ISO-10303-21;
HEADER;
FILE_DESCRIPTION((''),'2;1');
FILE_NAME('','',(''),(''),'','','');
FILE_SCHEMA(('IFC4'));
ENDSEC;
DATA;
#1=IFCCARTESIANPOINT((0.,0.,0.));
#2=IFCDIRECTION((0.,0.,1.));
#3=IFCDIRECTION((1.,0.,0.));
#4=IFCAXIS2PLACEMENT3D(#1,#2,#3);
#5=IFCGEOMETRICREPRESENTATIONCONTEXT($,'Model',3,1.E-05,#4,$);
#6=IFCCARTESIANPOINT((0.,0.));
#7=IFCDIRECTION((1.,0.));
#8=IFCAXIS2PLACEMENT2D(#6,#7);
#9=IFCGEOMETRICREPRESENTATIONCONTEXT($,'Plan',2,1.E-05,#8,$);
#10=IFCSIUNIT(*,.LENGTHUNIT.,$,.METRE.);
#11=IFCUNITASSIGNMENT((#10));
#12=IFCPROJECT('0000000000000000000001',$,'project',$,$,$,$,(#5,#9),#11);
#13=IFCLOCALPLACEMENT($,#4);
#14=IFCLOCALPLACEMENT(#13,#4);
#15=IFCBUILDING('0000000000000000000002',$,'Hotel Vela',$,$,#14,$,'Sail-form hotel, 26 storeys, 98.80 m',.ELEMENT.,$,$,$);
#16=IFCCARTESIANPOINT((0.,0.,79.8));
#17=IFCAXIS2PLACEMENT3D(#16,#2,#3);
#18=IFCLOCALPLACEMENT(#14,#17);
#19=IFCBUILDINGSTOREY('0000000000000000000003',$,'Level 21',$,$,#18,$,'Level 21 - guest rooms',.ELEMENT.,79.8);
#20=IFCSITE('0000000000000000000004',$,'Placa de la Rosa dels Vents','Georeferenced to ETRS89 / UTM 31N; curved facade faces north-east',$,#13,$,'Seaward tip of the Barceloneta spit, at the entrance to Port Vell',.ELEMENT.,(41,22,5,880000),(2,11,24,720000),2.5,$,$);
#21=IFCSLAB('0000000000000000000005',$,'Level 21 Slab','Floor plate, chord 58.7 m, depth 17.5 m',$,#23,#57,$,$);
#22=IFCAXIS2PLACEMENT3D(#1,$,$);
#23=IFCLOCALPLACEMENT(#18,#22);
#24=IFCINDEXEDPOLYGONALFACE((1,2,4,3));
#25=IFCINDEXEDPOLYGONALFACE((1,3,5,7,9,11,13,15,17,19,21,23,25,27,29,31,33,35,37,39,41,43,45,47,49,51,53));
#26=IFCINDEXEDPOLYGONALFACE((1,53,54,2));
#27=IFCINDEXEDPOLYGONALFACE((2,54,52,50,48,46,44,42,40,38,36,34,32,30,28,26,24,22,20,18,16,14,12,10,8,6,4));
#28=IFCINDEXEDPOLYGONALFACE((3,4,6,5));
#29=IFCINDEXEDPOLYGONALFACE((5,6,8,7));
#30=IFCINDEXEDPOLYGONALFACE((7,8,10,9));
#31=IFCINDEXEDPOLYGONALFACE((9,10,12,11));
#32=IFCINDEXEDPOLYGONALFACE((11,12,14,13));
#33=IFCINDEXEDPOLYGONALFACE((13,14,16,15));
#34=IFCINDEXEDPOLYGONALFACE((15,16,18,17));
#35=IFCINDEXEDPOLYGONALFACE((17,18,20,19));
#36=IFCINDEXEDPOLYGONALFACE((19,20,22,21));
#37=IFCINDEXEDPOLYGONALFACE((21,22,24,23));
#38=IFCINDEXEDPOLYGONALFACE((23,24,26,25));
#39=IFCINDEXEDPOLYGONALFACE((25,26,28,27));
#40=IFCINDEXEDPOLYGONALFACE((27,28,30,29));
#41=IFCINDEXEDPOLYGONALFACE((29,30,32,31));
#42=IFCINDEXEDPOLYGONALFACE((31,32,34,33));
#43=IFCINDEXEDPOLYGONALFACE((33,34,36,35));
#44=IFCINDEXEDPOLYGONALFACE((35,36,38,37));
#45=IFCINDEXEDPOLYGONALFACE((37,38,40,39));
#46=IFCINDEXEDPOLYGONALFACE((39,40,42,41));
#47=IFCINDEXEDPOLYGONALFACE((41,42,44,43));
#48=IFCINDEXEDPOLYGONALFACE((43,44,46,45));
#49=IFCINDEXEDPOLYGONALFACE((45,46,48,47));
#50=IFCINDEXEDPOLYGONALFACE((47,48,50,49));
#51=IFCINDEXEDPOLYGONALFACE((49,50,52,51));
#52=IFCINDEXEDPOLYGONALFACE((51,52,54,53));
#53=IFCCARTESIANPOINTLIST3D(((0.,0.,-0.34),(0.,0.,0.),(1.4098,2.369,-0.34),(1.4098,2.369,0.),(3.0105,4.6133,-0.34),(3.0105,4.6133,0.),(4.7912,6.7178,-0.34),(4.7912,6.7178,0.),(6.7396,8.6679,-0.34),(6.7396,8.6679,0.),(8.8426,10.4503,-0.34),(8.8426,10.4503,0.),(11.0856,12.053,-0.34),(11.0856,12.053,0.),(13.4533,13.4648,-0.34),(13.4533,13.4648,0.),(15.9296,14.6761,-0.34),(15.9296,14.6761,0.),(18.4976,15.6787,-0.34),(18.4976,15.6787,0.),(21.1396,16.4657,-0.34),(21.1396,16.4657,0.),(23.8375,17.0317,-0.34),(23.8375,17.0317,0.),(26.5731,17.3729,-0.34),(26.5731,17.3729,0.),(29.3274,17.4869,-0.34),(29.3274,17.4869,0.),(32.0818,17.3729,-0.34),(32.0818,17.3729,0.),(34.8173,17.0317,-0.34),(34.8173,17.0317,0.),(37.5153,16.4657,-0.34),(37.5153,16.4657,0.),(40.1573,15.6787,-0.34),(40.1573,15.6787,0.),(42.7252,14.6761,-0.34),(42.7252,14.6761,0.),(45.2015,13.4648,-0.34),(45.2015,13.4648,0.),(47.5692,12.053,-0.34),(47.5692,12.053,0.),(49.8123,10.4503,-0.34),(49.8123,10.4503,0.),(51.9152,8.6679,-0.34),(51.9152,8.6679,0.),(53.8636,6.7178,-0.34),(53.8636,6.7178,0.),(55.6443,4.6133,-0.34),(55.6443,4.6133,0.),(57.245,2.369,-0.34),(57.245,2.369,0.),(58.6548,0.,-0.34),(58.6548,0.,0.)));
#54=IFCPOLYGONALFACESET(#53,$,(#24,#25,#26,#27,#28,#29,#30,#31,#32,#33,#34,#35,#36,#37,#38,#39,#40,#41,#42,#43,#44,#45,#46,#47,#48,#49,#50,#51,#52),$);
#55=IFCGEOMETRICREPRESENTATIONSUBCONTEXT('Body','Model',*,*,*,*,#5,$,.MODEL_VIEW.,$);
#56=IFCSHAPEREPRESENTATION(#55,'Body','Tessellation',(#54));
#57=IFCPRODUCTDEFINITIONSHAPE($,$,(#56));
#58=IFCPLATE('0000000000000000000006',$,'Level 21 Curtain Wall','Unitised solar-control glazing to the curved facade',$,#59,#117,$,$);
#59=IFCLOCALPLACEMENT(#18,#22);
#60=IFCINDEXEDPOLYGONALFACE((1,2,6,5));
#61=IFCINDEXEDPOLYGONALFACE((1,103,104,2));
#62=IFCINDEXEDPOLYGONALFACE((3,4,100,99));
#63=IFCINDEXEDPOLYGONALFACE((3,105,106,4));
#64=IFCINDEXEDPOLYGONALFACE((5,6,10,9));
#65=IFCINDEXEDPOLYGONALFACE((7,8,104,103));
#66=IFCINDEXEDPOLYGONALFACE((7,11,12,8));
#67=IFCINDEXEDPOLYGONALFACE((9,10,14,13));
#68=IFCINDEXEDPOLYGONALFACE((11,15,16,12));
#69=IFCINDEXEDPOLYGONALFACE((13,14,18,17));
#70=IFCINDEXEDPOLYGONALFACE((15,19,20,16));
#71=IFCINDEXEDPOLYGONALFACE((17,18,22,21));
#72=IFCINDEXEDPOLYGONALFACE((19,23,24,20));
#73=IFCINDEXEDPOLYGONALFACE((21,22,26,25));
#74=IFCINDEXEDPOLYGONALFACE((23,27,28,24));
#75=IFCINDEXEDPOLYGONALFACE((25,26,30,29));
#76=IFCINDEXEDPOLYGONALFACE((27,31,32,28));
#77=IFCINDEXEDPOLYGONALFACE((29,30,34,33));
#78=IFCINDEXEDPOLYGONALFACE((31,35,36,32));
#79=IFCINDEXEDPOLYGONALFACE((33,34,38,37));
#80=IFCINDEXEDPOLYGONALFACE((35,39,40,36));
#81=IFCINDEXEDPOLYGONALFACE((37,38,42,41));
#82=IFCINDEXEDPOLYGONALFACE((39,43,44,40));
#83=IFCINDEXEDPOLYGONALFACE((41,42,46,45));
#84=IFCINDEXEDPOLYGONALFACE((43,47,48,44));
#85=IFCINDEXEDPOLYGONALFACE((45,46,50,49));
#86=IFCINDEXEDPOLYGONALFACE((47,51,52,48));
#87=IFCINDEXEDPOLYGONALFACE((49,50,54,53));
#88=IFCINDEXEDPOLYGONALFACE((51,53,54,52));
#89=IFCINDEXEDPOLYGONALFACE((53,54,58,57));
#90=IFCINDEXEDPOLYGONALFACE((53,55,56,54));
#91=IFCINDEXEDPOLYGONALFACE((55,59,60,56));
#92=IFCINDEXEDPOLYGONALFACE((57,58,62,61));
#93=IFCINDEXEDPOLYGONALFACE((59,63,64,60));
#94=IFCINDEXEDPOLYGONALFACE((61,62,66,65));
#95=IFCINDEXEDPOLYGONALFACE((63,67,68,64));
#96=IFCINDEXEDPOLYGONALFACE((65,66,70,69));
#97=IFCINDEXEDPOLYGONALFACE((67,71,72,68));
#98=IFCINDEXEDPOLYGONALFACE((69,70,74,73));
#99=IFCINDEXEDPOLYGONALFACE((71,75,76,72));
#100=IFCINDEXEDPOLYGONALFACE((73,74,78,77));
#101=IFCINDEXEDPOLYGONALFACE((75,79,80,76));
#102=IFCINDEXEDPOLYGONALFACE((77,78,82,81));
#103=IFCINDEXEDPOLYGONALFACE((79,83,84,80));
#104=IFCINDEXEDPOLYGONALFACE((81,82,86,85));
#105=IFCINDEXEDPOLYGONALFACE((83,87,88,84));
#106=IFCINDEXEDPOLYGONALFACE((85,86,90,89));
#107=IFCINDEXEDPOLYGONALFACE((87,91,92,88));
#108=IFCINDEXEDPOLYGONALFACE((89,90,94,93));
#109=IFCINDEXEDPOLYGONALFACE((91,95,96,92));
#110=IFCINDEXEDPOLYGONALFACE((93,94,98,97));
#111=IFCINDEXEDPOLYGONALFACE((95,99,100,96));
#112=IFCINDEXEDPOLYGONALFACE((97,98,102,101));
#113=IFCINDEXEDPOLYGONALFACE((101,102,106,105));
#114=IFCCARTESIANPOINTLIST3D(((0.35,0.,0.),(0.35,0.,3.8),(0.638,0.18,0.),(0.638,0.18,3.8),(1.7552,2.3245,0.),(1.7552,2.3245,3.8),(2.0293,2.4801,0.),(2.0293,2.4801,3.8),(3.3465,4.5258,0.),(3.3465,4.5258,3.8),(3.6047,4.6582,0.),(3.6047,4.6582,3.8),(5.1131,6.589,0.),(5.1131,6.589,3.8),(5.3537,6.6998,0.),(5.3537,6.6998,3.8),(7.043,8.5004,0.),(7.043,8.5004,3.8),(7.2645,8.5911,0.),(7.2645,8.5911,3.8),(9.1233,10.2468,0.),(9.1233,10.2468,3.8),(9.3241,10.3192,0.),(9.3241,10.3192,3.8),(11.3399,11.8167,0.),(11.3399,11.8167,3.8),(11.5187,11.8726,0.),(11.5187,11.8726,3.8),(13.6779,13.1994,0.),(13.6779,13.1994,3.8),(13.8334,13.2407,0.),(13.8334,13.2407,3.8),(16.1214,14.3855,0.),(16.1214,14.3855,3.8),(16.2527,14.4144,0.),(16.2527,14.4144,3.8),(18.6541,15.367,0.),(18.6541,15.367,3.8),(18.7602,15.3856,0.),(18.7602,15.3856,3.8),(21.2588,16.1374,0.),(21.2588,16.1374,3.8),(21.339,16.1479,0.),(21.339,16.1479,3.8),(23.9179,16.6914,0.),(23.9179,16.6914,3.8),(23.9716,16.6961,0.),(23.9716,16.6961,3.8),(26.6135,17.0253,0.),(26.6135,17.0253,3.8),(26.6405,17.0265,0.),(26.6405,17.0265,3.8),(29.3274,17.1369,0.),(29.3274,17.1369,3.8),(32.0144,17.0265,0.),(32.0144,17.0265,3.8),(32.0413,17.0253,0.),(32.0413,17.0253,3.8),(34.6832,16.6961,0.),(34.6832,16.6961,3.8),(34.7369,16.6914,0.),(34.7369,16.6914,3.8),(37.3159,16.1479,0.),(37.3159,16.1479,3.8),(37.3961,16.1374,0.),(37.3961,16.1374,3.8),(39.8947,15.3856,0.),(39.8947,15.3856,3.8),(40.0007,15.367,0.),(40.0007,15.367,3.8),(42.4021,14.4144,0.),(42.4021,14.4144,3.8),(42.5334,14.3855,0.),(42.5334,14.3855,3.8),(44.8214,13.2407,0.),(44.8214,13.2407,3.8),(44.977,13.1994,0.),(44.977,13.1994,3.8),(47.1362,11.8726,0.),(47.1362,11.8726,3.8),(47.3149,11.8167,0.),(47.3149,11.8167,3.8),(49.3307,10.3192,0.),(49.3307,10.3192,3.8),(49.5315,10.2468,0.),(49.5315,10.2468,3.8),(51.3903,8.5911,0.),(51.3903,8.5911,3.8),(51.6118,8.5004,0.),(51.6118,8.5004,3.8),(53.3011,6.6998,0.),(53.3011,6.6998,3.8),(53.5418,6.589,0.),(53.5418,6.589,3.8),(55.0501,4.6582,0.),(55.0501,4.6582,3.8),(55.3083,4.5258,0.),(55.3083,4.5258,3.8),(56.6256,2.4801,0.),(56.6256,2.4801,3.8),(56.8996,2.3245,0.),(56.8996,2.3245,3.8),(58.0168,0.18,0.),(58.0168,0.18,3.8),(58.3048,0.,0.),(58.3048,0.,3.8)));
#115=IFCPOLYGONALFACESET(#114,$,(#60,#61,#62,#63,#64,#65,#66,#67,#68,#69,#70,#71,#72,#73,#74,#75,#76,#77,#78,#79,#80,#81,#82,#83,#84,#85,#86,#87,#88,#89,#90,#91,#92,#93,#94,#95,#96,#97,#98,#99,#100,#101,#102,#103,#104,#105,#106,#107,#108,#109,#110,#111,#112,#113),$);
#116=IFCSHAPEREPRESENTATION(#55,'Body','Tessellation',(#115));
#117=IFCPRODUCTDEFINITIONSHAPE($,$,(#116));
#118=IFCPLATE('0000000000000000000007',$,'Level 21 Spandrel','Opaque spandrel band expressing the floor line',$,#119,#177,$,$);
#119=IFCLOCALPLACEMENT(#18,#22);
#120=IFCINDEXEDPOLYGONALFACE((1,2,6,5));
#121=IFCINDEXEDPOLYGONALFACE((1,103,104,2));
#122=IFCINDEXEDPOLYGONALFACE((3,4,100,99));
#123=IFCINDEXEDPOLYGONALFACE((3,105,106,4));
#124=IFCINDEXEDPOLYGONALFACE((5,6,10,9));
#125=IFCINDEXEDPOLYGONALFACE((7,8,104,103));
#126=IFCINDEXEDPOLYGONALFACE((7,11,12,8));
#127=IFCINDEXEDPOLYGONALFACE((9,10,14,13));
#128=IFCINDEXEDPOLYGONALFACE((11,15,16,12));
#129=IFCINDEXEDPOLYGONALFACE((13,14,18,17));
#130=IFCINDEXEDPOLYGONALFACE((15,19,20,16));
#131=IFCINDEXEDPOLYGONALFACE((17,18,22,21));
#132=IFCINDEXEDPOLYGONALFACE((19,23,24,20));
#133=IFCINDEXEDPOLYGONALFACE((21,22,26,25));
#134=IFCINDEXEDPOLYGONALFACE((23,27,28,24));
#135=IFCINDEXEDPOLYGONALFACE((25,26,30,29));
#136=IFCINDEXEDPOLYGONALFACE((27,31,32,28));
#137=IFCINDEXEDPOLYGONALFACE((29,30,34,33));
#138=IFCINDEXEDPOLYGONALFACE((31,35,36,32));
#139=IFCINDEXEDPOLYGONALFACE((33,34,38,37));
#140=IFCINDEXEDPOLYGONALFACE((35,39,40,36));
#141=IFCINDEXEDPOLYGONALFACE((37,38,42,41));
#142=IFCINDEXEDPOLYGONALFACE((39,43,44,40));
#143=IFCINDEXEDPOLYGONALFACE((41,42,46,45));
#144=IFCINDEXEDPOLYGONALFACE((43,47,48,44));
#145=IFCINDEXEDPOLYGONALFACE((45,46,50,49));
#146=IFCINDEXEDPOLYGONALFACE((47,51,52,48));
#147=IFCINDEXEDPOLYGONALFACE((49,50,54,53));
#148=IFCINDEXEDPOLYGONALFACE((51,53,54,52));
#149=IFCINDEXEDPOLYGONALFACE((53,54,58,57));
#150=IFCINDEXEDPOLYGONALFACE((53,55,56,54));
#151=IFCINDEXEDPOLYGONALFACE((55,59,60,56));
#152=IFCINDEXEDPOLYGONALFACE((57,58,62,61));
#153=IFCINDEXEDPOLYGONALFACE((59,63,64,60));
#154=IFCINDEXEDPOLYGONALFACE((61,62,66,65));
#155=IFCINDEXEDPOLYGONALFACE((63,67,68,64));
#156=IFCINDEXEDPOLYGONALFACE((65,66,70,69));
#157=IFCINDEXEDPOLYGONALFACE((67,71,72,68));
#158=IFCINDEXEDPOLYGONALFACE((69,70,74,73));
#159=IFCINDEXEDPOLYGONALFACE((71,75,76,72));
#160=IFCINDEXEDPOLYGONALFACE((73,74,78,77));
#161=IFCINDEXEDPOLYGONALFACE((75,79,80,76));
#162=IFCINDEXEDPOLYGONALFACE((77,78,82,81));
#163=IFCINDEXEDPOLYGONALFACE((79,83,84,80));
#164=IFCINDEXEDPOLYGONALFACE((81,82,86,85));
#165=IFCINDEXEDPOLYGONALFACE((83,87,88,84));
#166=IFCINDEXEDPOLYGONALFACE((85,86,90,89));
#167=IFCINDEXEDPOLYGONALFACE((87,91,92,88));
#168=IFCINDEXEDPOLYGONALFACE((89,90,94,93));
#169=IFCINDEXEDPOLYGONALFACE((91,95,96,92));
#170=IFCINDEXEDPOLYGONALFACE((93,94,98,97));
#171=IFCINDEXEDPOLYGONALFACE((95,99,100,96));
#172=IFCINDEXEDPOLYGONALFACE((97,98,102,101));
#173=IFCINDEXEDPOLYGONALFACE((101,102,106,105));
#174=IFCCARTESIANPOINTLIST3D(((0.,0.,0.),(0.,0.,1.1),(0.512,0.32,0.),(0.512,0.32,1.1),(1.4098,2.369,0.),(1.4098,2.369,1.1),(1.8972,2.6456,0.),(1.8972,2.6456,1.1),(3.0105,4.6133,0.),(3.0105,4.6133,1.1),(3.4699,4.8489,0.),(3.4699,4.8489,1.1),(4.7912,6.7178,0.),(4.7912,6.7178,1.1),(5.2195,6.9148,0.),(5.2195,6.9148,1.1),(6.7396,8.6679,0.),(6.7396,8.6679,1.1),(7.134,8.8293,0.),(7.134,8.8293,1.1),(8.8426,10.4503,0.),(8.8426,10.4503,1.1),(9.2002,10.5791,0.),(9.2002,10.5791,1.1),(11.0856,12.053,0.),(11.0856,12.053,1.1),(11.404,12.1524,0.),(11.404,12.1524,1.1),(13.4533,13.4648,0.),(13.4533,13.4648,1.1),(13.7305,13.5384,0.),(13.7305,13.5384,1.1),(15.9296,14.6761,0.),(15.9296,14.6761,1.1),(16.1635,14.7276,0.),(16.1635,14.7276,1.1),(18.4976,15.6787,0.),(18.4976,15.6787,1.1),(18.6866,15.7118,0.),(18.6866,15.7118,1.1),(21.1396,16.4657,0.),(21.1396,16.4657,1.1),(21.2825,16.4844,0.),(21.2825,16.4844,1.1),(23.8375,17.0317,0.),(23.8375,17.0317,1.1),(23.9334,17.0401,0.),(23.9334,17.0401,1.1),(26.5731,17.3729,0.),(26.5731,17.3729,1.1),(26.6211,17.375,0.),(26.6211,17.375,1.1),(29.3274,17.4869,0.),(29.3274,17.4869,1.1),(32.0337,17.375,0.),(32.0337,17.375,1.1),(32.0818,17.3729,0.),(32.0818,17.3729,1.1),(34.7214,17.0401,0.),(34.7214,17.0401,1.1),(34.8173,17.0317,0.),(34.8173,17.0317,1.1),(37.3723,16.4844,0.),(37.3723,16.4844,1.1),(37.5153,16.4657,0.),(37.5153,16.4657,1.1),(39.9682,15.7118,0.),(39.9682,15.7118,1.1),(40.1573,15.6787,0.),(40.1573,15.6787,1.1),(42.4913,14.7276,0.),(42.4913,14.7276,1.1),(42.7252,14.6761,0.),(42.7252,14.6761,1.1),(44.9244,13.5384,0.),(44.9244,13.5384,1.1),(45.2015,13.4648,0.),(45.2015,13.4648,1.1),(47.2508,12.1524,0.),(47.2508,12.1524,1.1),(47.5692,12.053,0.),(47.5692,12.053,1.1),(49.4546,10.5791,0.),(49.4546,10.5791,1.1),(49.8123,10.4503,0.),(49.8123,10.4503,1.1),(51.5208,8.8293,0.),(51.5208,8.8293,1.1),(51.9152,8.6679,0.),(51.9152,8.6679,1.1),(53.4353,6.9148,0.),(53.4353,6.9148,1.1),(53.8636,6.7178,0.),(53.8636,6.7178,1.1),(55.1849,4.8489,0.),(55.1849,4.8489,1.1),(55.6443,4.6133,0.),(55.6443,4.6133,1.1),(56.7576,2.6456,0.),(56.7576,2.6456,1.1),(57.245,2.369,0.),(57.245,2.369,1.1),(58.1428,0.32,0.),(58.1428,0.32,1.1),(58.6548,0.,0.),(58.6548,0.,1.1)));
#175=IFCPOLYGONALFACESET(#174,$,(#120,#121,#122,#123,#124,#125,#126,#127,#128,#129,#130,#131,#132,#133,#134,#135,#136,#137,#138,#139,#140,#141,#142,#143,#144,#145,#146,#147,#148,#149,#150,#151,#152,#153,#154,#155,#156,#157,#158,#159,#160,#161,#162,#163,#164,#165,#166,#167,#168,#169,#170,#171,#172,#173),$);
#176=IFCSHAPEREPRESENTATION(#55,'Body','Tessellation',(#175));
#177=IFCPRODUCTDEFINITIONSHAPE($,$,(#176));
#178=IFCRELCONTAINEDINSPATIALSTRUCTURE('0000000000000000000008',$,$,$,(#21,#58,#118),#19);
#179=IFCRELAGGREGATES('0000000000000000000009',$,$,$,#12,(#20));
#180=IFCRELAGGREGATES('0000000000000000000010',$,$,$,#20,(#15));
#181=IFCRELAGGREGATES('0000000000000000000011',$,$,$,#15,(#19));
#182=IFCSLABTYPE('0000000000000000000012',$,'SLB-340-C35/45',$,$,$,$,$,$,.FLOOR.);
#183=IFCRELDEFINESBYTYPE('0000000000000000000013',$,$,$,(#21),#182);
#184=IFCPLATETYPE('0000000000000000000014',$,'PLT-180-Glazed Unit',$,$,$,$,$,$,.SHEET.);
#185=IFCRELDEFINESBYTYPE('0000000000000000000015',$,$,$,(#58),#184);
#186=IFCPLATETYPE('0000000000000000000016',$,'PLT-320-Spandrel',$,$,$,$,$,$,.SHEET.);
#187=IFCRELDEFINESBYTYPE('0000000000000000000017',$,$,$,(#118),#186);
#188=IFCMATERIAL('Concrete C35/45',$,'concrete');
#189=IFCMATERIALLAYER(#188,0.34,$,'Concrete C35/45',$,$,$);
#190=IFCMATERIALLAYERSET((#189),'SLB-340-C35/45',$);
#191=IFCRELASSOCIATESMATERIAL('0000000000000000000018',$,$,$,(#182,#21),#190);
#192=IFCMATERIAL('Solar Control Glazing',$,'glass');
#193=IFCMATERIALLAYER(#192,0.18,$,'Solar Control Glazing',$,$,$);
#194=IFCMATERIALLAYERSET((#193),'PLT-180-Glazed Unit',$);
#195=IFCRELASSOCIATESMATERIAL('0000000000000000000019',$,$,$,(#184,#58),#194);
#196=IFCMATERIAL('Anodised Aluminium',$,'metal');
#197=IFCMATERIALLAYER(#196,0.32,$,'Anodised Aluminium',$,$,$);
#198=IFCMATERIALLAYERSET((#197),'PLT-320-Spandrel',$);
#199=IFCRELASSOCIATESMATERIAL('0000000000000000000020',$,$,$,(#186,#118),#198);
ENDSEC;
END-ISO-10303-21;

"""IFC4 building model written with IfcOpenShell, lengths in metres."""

from ifc_helpers import new_model, si_unit, frame, origin_with_axes, origin_2d_with_axis, place, context, subcontext, project, spatial, line, indexed_curve, outline, extrude, material, layer, layer_set, layer_usage, type_object, element, save


model = new_model("IFC4")

# Units and contexts
model_context = context("Model", 3, precision=1e-05, world=origin_with_axes())
plan_context = context("Plan", 2, precision=1e-05, world=origin_2d_with_axis())
body_context = subcontext(model_context, "Body", "Model", "MODEL_VIEW")
ifc_project = project(units=[si_unit("LENGTHUNIT", "METRE")], contexts=[model_context, plan_context])

# Site, building, storey
site_placement = place(None, origin_with_axes())
site = spatial("IfcSite", under=ifc_project, at=site_placement, Name="Placa de la Rosa dels Vents", Description="Georeferenced to ETRS89 / UTM 31N; curved facade faces north-east", LongName="Seaward tip of the Barceloneta spit, at the entrance to Port Vell", CompositionType="ELEMENT", RefLatitude=(41, 22, 5, 880000), RefLongitude=(2, 11, 24, 720000), RefElevation=2.5)
building_placement = place(site_placement, origin_with_axes())
building = spatial("IfcBuilding", under=site, at=building_placement, Name="Hotel Vela", LongName="Sail-form hotel, 26 storeys, 98.80 m", CompositionType="ELEMENT")
storey_placement = place(building_placement, frame((0.0, 0.0, 79.8), z_axis=(0.0, 0.0, 1.0), x_axis=(1.0, 0.0, 0.0)))
storey = spatial("IfcBuildingStorey", under=building, at=storey_placement, Name="Level 21", LongName="Level 21 - guest rooms", CompositionType="ELEMENT", Elevation=79.8)

# Slab
ifc_material_1 = material(Name="Concrete C35/45", Category="concrete")
ifc_layer_1 = layer(ifc_material_1, 0.34, Name="Concrete C35/45")
ifc_layer_set_1 = layer_set([ifc_layer_1], Name="SLB-340-C35/45")
ifc_layer_usage_1 = layer_usage(ifc_layer_set_1, "AXIS3", "POSITIVE", 0.0)
slab_type = type_object("IfcSlabType", Name="SLB-340-C35/45", PredefinedType="FLOOR", material=ifc_layer_set_1)
slab_placement = place(storey_placement, frame((0.0, 0.0, -0.34), z_axis=(0.0, 0.0, 1.0), x_axis=(1.0, 0.0, 0.0)))
element("IfcSlab", 1, at=slab_placement, inside=storey, type_object=slab_type, material=ifc_layer_usage_1, Name="Level 21 Slab", Description="Floor plate, chord 58.7 m, depth 17.5 m", context=body_context, shape_type="SweptSolid", body=[
    extrude(outline(indexed_curve([(0.0, 0.0), (58.6548, 0.0), (57.245, 2.369), (55.6443, 4.6133), (53.8636, 6.7178), (51.9152, 8.6679), (49.8123, 10.4503), (47.5692, 12.053), (45.2015, 13.4648), (42.7252, 14.6761), (40.1573, 15.6787), (37.5153, 16.4657), (34.8173, 17.0317), (32.0818, 17.3729), (29.3274, 17.4869), (26.5731, 17.3729), (23.8375, 17.0317), (21.1396, 16.4657), (18.4976, 15.6787), (15.9296, 14.6761), (13.4533, 13.4648), (11.0856, 12.053), (8.8426, 10.4503), (6.7396, 8.6679), (4.7912, 6.7178), (3.0105, 4.6133), (1.4098, 2.369)], segments=[line(1, 2, 3, 4, 5, 6, 7, 8, 9, 10, 11, 12, 13, 14, 15, 16, 17, 18, 19, 20, 21, 22, 23, 24, 25, 26, 27, 1)])), origin_with_axes(), (0.0, 0.0, 1.0), 0.34),
])

# Plates
ifc_material_2 = material(Name="Solar Control Glazing", Category="glass")
ifc_layer_2 = layer(ifc_material_2, 0.18, Name="Solar Control Glazing")
ifc_layer_set_2 = layer_set([ifc_layer_2], Name="PLT-180-Glazed Unit")
ifc_layer_usage_2 = layer_usage(ifc_layer_set_2, "AXIS2", "POSITIVE", 0.0)
plate_type_1 = type_object("IfcPlateType", Name="PLT-180-Glazed Unit", PredefinedType="SHEET", material=ifc_layer_set_2)
plate_1_placement = place(storey_placement, frame((0.35, 0.0, 0.0), z_axis=(0.0, 0.0, 1.0), x_axis=(1.0, 0.0, 0.0)))
element("IfcPlate", 2, at=plate_1_placement, inside=storey, type_object=plate_type_1, material=ifc_layer_usage_2, Name="Level 21 Curtain Wall", Description="Unitised solar-control glazing to the curved facade", context=body_context, shape_type="SweptSolid", body=[
    extrude(outline(indexed_curve([(57.9548, 0.0), (56.5496, 2.3245), (54.9583, 4.5258), (53.1918, 6.589), (51.2618, 8.5004), (49.1815, 10.2468), (46.9649, 11.8167), (44.627, 13.1994), (42.1834, 14.3855), (39.6507, 15.367), (37.0461, 16.1374), (34.3869, 16.6914), (31.6913, 17.0253), (28.9774, 17.1369), (26.2635, 17.0253), (23.5679, 16.6914), (20.9088, 16.1374), (18.3041, 15.367), (15.7714, 14.3855), (13.3279, 13.1994), (10.9899, 11.8167), (8.7733, 10.2468), (6.693, 8.5004), (4.7631, 6.589), (2.9965, 4.5258), (1.4052, 2.3245), (0.0, 0.0), (57.6668, 0.18), (1.6793, 2.4801), (3.2547, 4.6582), (5.0037, 6.6998), (6.9145, 8.5911), (8.9741, 10.3192), (11.1687, 11.8726), (13.4834, 13.2407), (15.9027, 14.4144), (18.4102, 15.3856), (20.989, 16.1479), (23.6216, 16.6961), (26.2905, 17.0265), (28.9774, 17.1369), (31.6644, 17.0265), (34.3332, 16.6961), (36.9659, 16.1479), (39.5447, 15.3856), (42.0521, 14.4144), (44.4714, 13.2407), (46.7862, 11.8726), (48.9807, 10.3192), (51.0403, 8.5911), (52.9511, 6.6998), (54.7001, 4.6582), (56.2756, 2.4801), (0.288, 0.18)], segments=[line(1, 2, 3, 4, 5, 6, 7, 8, 9, 10, 11, 12, 13, 14, 15, 16, 17, 18, 19, 20, 21, 22, 23, 24, 25, 26, 27, 28, 29, 30, 31, 32, 33, 34, 35, 36, 37, 38, 39, 40, 41, 42, 43, 44, 45, 46, 47, 48, 49, 50, 51, 52, 53, 54, 1)])), origin_with_axes(), (0.0, 0.0, 1.0), 3.8),
])
ifc_material_3 = material(Name="Anodised Aluminium", Category="metal")
ifc_layer_3 = layer(ifc_material_3, 0.32, Name="Anodised Aluminium")
ifc_layer_set_3 = layer_set([ifc_layer_3], Name="PLT-320-Spandrel")
ifc_layer_usage_3 = layer_usage(ifc_layer_set_3, "AXIS2", "POSITIVE", 0.0)
plate_type_2 = type_object("IfcPlateType", Name="PLT-320-Spandrel", PredefinedType="SHEET", material=ifc_layer_set_3)
plate_2_placement = place(storey_placement, origin_with_axes())
element("IfcPlate", 3, at=plate_2_placement, inside=storey, type_object=plate_type_2, material=ifc_layer_usage_3, Name="Level 21 Spandrel", Description="Opaque spandrel band expressing the floor line", context=body_context, shape_type="SweptSolid", body=[
    extrude(outline(indexed_curve([(58.6548, 0.0), (57.245, 2.369), (55.6443, 4.6133), (53.8636, 6.7178), (51.9152, 8.6679), (49.8123, 10.4503), (47.5692, 12.053), (45.2015, 13.4648), (42.7252, 14.6761), (40.1573, 15.6787), (37.5153, 16.4657), (34.8173, 17.0317), (32.0818, 17.3729), (29.3274, 17.4869), (26.5731, 17.3729), (23.8375, 17.0317), (21.1396, 16.4657), (18.4976, 15.6787), (15.9296, 14.6761), (13.4533, 13.4648), (11.0856, 12.053), (8.8426, 10.4503), (6.7396, 8.6679), (4.7912, 6.7178), (3.0105, 4.6133), (1.4098, 2.369), (0.0, 0.0), (58.1428, 0.32), (1.8972, 2.6456), (3.4699, 4.8489), (5.2195, 6.9148), (7.134, 8.8293), (9.2002, 10.5791), (11.404, 12.1524), (13.7305, 13.5384), (16.1635, 14.7276), (18.6866, 15.7118), (21.2825, 16.4844), (23.9334, 17.0401), (26.6211, 17.375), (29.3274, 17.4869), (32.0337, 17.375), (34.7214, 17.0401), (37.3723, 16.4844), (39.9682, 15.7118), (42.4913, 14.7276), (44.9244, 13.5384), (47.2508, 12.1524), (49.4546, 10.5791), (51.5208, 8.8293), (53.4353, 6.9148), (55.1849, 4.8489), (56.7576, 2.6456), (0.512, 0.32)], segments=[line(1, 2, 3, 4, 5, 6, 7, 8, 9, 10, 11, 12, 13, 14, 15, 16, 17, 18, 19, 20, 21, 22, 23, 24, 25, 26, 27, 28, 29, 30, 31, 32, 33, 34, 35, 36, 37, 38, 39, 40, 41, 42, 43, 44, 45, 46, 47, 48, 49, 50, 51, 52, 53, 54, 1)])), origin_with_axes(), (0.0, 0.0, 1.0), 1.1),
])

save(model, "model.ifc")
